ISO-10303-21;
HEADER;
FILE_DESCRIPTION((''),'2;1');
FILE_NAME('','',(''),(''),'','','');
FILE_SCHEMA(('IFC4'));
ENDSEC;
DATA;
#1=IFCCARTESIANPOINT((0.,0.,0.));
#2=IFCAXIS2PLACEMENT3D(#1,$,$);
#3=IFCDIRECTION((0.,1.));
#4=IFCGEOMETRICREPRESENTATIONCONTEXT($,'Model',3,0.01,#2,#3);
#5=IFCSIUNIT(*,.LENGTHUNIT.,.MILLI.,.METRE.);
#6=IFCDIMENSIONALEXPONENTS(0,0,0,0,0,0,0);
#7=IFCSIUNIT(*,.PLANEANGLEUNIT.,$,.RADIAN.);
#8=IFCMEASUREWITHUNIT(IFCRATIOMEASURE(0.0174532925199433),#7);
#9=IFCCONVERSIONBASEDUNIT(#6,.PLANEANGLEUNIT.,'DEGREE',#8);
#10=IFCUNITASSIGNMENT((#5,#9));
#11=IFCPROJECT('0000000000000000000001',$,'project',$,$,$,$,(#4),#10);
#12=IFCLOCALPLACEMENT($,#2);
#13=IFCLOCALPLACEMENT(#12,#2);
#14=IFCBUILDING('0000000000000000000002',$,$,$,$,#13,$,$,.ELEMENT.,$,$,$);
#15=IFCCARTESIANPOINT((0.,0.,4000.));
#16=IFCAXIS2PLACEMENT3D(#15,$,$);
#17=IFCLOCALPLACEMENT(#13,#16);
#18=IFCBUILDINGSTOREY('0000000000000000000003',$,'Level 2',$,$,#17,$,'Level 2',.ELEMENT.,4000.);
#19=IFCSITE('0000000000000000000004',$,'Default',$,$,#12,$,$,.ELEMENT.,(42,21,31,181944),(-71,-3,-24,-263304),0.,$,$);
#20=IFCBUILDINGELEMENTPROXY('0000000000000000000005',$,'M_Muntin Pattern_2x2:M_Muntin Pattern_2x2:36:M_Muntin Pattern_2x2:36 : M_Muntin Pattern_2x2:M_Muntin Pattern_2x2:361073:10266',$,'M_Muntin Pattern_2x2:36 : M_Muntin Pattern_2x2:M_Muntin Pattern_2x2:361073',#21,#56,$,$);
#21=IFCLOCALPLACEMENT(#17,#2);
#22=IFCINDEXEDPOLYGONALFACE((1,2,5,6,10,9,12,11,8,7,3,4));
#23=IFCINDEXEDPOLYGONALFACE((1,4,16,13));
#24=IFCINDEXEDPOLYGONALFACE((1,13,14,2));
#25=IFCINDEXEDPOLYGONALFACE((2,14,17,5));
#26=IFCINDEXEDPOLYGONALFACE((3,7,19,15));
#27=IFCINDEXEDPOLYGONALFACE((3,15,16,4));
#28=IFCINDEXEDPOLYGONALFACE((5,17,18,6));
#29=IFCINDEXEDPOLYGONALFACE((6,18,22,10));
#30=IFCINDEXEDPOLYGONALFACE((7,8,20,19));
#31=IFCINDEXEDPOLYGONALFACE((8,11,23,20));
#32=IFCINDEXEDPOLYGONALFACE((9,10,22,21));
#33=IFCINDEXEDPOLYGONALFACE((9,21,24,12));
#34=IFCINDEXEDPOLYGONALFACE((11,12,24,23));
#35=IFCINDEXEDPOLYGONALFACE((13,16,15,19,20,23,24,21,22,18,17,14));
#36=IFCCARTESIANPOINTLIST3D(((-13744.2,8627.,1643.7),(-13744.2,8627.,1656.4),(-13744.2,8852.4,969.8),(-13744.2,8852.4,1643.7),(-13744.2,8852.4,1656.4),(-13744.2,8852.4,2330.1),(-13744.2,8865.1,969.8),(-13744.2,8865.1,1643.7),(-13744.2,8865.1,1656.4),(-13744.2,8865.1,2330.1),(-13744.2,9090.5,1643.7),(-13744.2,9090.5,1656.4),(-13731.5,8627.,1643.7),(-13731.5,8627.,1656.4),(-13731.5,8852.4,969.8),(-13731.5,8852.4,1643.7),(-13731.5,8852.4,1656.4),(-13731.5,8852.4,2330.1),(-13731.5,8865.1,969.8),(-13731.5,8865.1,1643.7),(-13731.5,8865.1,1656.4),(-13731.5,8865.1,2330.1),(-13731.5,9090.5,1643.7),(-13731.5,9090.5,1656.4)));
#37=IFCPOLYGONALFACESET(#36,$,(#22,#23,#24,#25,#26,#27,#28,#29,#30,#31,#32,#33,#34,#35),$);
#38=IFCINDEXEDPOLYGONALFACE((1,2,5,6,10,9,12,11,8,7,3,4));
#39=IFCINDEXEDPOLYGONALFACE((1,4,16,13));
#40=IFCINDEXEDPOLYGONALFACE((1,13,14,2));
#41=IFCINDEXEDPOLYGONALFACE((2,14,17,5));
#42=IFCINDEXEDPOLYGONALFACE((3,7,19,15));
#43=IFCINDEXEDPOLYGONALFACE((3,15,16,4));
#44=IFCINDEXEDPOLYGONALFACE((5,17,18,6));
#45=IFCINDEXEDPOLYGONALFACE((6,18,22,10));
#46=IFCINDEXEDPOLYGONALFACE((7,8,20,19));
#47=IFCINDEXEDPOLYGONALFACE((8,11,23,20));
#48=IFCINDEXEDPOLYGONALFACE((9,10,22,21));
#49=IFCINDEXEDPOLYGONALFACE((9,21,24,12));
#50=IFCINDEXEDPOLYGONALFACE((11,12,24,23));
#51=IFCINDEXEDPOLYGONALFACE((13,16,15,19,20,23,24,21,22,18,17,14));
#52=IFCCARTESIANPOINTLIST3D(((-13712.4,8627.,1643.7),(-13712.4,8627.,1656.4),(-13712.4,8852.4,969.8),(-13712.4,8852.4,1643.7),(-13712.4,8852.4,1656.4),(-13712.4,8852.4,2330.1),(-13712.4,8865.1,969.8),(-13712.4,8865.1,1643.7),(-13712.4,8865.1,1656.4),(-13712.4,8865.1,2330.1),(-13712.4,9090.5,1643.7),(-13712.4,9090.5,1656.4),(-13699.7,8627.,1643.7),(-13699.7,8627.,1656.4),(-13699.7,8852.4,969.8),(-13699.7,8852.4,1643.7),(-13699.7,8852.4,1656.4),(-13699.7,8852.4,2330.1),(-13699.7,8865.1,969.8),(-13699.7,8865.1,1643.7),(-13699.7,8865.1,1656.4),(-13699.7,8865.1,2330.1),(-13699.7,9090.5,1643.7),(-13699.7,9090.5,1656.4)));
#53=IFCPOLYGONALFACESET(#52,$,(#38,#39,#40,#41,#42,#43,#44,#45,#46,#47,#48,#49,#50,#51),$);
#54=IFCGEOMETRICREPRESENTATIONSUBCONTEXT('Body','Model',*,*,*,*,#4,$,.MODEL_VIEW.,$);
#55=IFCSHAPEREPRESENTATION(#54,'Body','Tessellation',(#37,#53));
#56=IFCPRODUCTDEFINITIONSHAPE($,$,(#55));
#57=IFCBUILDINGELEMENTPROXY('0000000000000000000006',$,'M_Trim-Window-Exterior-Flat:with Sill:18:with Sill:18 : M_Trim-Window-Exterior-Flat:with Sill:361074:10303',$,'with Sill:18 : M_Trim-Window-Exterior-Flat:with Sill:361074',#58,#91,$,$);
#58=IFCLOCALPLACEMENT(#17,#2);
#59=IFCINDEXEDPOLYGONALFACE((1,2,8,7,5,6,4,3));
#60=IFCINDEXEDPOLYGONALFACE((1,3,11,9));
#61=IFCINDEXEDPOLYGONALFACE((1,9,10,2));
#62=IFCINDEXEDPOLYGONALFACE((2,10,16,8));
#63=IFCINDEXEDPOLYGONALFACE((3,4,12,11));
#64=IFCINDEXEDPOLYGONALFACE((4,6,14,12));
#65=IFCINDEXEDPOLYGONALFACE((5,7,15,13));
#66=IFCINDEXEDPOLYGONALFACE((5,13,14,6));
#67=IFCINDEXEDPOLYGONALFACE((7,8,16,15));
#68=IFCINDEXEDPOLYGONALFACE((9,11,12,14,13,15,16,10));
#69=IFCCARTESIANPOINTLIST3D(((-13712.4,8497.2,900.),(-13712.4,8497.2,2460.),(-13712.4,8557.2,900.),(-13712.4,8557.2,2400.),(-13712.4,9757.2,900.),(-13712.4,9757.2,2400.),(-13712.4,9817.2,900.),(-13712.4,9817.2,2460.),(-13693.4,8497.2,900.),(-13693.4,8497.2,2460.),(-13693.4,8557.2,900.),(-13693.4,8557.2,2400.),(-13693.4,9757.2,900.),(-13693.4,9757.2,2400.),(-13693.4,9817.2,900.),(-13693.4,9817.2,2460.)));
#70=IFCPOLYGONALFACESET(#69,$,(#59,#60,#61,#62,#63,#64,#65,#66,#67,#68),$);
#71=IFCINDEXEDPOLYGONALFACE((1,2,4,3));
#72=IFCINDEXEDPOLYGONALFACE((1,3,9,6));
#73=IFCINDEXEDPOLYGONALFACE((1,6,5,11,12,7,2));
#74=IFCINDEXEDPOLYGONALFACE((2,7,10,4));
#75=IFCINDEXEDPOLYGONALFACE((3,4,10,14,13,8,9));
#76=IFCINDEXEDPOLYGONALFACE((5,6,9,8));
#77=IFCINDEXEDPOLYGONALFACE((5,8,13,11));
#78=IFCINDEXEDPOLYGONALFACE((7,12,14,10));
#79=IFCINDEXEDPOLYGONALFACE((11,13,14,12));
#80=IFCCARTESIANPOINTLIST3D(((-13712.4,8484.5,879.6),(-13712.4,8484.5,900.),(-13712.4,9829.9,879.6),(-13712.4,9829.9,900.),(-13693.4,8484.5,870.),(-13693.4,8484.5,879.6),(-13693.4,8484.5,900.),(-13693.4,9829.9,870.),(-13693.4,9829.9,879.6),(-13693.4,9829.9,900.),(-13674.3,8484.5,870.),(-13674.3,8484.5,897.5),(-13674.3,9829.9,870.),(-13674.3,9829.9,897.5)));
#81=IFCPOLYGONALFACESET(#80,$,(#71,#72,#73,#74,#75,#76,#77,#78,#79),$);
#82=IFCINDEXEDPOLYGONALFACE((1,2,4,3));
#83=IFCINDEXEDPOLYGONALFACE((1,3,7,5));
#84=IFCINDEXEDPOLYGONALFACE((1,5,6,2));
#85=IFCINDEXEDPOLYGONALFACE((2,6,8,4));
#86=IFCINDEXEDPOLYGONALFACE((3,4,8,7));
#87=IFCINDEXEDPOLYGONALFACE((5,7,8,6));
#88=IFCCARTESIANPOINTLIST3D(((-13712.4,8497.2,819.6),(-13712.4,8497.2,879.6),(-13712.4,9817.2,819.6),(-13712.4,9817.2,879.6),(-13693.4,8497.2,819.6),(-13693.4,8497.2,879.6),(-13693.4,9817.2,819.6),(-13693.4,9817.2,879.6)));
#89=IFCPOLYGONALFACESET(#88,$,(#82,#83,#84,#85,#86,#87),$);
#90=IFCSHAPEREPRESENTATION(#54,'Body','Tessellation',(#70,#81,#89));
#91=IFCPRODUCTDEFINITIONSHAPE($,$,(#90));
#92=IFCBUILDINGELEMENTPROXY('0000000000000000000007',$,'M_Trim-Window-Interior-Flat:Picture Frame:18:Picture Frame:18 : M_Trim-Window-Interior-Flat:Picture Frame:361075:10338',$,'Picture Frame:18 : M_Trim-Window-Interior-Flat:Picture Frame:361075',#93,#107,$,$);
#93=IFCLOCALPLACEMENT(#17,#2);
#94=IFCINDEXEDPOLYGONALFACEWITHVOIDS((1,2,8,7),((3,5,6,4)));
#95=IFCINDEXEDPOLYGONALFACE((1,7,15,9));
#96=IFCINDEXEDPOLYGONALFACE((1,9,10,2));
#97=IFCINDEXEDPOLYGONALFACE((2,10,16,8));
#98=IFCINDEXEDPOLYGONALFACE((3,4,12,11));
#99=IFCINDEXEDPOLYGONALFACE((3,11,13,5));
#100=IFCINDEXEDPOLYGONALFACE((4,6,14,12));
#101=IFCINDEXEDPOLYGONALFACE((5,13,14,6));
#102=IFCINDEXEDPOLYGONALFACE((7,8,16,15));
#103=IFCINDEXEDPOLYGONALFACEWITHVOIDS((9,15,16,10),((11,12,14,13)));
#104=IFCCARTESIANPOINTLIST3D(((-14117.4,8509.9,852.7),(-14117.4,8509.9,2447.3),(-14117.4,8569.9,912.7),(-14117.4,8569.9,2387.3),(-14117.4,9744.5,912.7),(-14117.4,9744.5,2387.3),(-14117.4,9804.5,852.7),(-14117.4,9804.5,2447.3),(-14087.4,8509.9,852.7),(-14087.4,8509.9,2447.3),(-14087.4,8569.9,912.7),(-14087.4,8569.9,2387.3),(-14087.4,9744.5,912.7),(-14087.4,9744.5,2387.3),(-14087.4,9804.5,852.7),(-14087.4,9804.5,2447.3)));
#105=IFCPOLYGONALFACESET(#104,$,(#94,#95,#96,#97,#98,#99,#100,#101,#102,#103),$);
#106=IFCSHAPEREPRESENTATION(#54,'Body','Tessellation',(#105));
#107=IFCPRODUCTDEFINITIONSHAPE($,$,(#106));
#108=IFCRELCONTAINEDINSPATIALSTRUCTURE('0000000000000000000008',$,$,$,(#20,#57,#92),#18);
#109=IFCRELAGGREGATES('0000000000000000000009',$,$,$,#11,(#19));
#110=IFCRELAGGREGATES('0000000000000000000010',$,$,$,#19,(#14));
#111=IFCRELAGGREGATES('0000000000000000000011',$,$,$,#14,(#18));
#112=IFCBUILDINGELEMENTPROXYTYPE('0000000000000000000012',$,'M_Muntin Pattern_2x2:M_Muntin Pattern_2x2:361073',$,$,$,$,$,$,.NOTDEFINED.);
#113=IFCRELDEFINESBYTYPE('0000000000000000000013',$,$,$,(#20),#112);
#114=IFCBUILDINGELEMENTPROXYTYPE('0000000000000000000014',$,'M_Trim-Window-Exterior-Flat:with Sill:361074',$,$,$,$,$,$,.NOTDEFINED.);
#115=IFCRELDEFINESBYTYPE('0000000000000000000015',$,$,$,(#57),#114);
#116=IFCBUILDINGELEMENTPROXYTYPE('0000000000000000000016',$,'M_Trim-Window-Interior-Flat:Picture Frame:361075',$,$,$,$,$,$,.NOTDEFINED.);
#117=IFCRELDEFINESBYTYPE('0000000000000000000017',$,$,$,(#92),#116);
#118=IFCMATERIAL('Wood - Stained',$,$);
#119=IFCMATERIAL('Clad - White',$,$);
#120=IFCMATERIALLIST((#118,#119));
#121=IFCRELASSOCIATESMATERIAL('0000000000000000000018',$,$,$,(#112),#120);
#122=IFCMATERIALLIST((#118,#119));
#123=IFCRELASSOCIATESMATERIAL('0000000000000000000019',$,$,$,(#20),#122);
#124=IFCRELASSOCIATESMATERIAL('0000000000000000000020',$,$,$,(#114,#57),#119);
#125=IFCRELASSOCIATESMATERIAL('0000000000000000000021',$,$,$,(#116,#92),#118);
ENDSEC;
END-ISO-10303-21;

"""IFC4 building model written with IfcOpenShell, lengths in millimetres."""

from ifc_helpers import new_model, entity, si_unit, converted_unit, direction, frame, frame_2d, origin, place, context, subcontext, project, spatial, polyline, rectangle, outline, extrude, source, transform, mapped, material, material_list, type_object, type_shapes, element, save


model = new_model("IFC4")

# Units and contexts
model_context = context("Model", 3, precision=0.01, world=origin(), true_north=direction((0.0, 1.0)))
body_context = subcontext(model_context, "Body", "Model", "MODEL_VIEW")
ifc_project = project(units=[si_unit("LENGTHUNIT", "METRE", prefix="MILLI"), converted_unit("PLANEANGLEUNIT", "DEGREE", entity("IfcRatioMeasure", 0.0174532925199433), si_unit("PLANEANGLEUNIT", "RADIAN"), dimensions=[0, 0, 0, 0, 0, 0, 0])], contexts=[model_context])

# Site, building, storey
site_placement = place(None, origin())
site = spatial("IfcSite", under=ifc_project, at=site_placement, Name="Default", CompositionType="ELEMENT", RefLatitude=(42, 21, 31, 181944), RefLongitude=(-71, -3, -24, -263304), RefElevation=0.0)
building_placement = place(site_placement, origin())
building = spatial("IfcBuilding", under=site, at=building_placement, CompositionType="ELEMENT")
storey_placement = place(building_placement, frame((0.0, 0.0, 4000.0)))
storey = spatial("IfcBuildingStorey", under=building, at=storey_placement, Name="Level 2", LongName="Level 2", CompositionType="ELEMENT", Elevation=4000.0)

# Building element proxies
ifc_material_1 = material(Name="Clad - White")
ifc_material_2 = material(Name="Wood - Stained")
ifc_material_list_1 = material_list([ifc_material_2, ifc_material_1])
ifc_material_list_2 = material_list([ifc_material_2, ifc_material_1])
building_element_proxy_type_1 = type_object("IfcBuildingElementProxyType", Name="M_Muntin Pattern_2x2:M_Muntin Pattern_2x2:361073", PredefinedType="NOTDEFINED", material=ifc_material_list_2)
shared_shape_1 = source(origin(), body_context, "Body", "SweptSolid", [
    extrude(outline(polyline([(-680.1, 6.4), (-680.1, -6.3), (-6.4, -6.3), (-6.4, -231.7), (6.3, -231.7), (6.3, -6.3), (680.2, -6.3), (680.2, 6.4), (6.3, 6.4), (6.3, 231.7), (-6.4, 231.7), (-6.4, 6.4), (-680.1, 6.4)])), frame((-13744.2, 8858.7, 5650.0), z_axis=(-1.0, 0.0, 0.0), x_axis=(0.0, 0.0, -1.0)), (0.0, 0.0, -1.0), 12.7),
    extrude(outline(polyline([(-680.1, 6.4), (-680.1, -6.3), (-6.4, -6.3), (-6.4, -231.7), (6.3, -231.7), (6.3, -6.3), (680.2, -6.3), (680.2, 6.4), (6.3, 6.4), (6.3, 231.7), (-6.4, 231.7), (-6.4, 6.4), (-680.1, 6.4)])), frame((-13712.4, 8858.7, 5650.0), z_axis=(-1.0, 0.0, 0.0), x_axis=(0.0, 0.0, -1.0)), (0.0, 0.0, -1.0), 12.7),
])
type_shapes(building_element_proxy_type_1, [shared_shape_1])
proxy_1_placement = place(storey_placement, frame((0.0, 0.0, -4000.0)))
element("IfcBuildingElementProxy", 1, at=proxy_1_placement, inside=storey, type_object=building_element_proxy_type_1, material=ifc_material_list_1, Name="M_Muntin Pattern_2x2:M_Muntin Pattern_2x2:36:M_Muntin Pattern_2x2:36 : M_Muntin Pattern_2x2:M_Muntin Pattern_2x2:361073:10266", ObjectType="M_Muntin Pattern_2x2:36 : M_Muntin Pattern_2x2:M_Muntin Pattern_2x2:361073", context=body_context, shape_type="MappedRepresentation", body=[
    mapped(shared_shape_1, transform((0.0, 0.0, 0.0), scale=1.0)),
])
building_element_proxy_type_2 = type_object("IfcBuildingElementProxyType", Name="M_Trim-Window-Exterior-Flat:with Sill:361074", PredefinedType="NOTDEFINED", material=ifc_material_1)
shared_shape_2 = source(origin(), body_context, "Body", "SweptSolid", [
    extrude(outline(polyline([(-660.0, -765.0), (-600.0, -765.0), (-600.0, 735.0), (600.0, 735.0), (600.0, -765.0), (660.0, -765.0), (660.0, 795.0), (-660.0, 795.0), (-660.0, -765.0)])), frame((-13712.4, 9157.2, 5665.0), z_axis=(1.0, 0.0, 0.0), x_axis=(0.0, 1.0, 0.0)), (0.0, 0.0, 1.0), 19.1),
    extrude(outline(polyline([(-15.2, 0.0), (-15.2, -19.0), (12.3, -19.0), (14.8, 0.0), (14.8, 19.0), (-5.7, 19.0), (-5.7, 0.0), (-15.2, 0.0)])), frame((-13693.4, 8484.5, 4885.2), z_axis=(0.0, -1.0, 0.0), x_axis=(0.0, 0.0, 1.0)), (0.0, 0.0, -1.0), 1345.4),
    extrude(rectangle(XDim=19.1, YDim=1320.0, at=frame_2d((0.0, 0.0), x_axis=(1.0, 0.0))), frame((-13702.9, 9157.2, 4819.6), z_axis=(0.0, 0.0, 1.0), x_axis=(-1.0, 0.0, 0.0)), (0.0, 0.0, 1.0), 60.0),
])
type_shapes(building_element_proxy_type_2, [shared_shape_2])
proxy_2_placement = place(storey_placement, frame((0.0, 0.0, -4000.0)))
element("IfcBuildingElementProxy", 2, at=proxy_2_placement, inside=storey, type_object=building_element_proxy_type_2, material=ifc_material_1, Name="M_Trim-Window-Exterior-Flat:with Sill:18:with Sill:18 : M_Trim-Window-Exterior-Flat:with Sill:361074:10303", ObjectType="with Sill:18 : M_Trim-Window-Exterior-Flat:with Sill:361074", context=body_context, shape_type="MappedRepresentation", body=[
    mapped(shared_shape_2, transform((0.0, 0.0, 0.0), scale=1.0)),
])
building_element_proxy_type_3 = type_object("IfcBuildingElementProxyType", Name="M_Trim-Window-Interior-Flat:Picture Frame:361075", PredefinedType="NOTDEFINED", material=ifc_material_2)
shared_shape_3 = source(origin(), body_context, "Body", "SweptSolid", [
    extrude(outline(polyline([(-647.3, -797.3), (647.3, -797.3), (647.3, 797.3), (-647.3, 797.3), (-647.3, -797.3)]), holes=[polyline([(587.3, 737.3), (587.3, -737.3), (-587.3, -737.3), (-587.3, 737.3), (587.3, 737.3)])]), frame((-14117.4, 9157.2, 5650.0), z_axis=(1.0, 0.0, 0.0), x_axis=(0.0, -1.0, 0.0)), (0.0, 0.0, 1.0), 30.0),
])
type_shapes(building_element_proxy_type_3, [shared_shape_3])
proxy_3_placement = place(storey_placement, frame((0.0, 0.0, -4000.0)))
element("IfcBuildingElementProxy", 3, at=proxy_3_placement, inside=storey, type_object=building_element_proxy_type_3, material=ifc_material_2, Name="M_Trim-Window-Interior-Flat:Picture Frame:18:Picture Frame:18 : M_Trim-Window-Interior-Flat:Picture Frame:361075:10338", ObjectType="Picture Frame:18 : M_Trim-Window-Interior-Flat:Picture Frame:361075", context=body_context, shape_type="MappedRepresentation", body=[
    mapped(shared_shape_3, transform((0.0, 0.0, 0.0), scale=1.0)),
])

save(model, "model.ifc")
